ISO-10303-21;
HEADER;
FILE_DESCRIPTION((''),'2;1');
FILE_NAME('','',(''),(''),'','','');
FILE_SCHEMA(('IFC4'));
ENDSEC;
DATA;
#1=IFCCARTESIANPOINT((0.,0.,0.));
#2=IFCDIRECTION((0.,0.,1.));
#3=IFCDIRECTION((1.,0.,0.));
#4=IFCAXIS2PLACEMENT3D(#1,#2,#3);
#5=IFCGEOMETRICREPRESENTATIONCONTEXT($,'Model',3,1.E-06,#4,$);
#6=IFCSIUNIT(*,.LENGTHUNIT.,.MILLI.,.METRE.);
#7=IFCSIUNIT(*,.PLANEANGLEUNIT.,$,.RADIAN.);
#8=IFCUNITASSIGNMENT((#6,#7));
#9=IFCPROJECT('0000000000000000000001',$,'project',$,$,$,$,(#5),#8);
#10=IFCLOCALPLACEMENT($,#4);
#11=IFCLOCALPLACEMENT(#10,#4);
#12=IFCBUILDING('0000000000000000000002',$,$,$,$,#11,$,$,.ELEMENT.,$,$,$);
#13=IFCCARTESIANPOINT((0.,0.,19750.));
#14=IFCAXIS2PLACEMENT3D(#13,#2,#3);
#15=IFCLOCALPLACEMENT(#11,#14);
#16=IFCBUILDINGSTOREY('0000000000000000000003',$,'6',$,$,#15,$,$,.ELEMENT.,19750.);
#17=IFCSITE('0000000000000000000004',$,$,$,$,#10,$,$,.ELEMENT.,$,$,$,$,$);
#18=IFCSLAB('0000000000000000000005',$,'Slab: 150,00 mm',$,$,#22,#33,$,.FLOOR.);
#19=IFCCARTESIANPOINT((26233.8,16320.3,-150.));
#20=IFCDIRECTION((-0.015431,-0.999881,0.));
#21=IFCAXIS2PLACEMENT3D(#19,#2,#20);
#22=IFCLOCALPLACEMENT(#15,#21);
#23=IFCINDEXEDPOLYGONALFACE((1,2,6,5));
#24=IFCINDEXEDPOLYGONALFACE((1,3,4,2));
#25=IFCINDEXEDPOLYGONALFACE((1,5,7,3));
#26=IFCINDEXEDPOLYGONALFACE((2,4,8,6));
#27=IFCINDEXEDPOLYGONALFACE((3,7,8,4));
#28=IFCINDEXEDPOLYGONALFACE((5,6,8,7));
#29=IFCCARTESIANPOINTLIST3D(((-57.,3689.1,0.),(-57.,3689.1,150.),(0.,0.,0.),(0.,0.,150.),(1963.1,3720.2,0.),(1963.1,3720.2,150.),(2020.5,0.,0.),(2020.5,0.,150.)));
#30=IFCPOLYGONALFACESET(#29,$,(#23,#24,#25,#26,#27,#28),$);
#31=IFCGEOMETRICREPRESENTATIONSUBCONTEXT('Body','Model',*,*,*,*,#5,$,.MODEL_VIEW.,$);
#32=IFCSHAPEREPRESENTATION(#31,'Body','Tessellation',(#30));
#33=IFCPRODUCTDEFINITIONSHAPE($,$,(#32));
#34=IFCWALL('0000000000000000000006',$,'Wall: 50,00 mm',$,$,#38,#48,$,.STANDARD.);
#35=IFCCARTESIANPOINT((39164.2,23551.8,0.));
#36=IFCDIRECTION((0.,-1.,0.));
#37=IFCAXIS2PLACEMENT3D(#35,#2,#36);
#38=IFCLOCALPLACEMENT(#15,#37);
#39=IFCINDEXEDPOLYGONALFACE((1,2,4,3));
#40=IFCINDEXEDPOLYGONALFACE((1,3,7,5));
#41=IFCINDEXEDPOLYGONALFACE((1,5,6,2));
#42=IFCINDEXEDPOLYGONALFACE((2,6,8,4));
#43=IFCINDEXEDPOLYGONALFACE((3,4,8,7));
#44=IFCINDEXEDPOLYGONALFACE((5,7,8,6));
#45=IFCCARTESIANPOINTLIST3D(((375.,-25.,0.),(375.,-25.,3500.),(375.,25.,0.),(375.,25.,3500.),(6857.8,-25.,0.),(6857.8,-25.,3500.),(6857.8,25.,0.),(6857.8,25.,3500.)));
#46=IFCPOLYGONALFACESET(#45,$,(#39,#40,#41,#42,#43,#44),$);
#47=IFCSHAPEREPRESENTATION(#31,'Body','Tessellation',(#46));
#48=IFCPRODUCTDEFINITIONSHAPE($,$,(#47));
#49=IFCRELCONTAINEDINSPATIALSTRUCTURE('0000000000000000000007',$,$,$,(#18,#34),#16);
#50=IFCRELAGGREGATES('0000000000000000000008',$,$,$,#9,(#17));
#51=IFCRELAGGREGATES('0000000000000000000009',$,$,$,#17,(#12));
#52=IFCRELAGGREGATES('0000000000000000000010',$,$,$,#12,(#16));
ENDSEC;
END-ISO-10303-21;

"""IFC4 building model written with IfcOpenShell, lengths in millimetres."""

from ifc_helpers import new_model, si_unit, frame, origin_with_axes, place, context, subcontext, project, spatial, line, indexed_curve, outline, extrude, element, save


model = new_model("IFC4")

# Units and contexts
model_context = context("Model", 3, precision=1e-06, world=origin_with_axes())
body_context = subcontext(model_context, "Body", "Model", "MODEL_VIEW")
ifc_project = project(units=[si_unit("LENGTHUNIT", "METRE", prefix="MILLI"), si_unit("PLANEANGLEUNIT", "RADIAN")], contexts=[model_context])

# Site, building, storey
site_placement = place(None, origin_with_axes())
site = spatial("IfcSite", under=ifc_project, at=site_placement, CompositionType="ELEMENT")
building_placement = place(site_placement, origin_with_axes())
building = spatial("IfcBuilding", under=site, at=building_placement, CompositionType="ELEMENT")
storey_placement = place(building_placement, frame((0.0, 0.0, 19750.0), z_axis=(0.0, 0.0, 1.0), x_axis=(1.0, 0.0, 0.0)))
storey = spatial("IfcBuildingStorey", under=building, at=storey_placement, Name="6", CompositionType="ELEMENT", Elevation=19750.0)

# Slab
slab_placement = place(storey_placement, frame((26233.8, 16320.3, -150.0), z_axis=(0.0, 0.0, 1.0), x_axis=(-0.015431, -0.999881, 0.0)))
element("IfcSlab", 1, at=slab_placement, inside=storey, Name="Slab: 150,00 mm", PredefinedType="FLOOR", context=body_context, shape_type="SweptSolid", body=[
    extrude(outline(indexed_curve([(0.0, 0.0), (2020.5, 0.0), (1963.1, 3720.2), (-57.0, 3689.1)], segments=[line(1, 2), line(2, 3), line(3, 4), line(4, 1)])), origin_with_axes(), (0.0, 0.0, 1.0), 150.0),
])

# Wall
wall_1_placement = place(storey_placement, frame((39164.2, 23551.8, 0.0), z_axis=(0.0, 0.0, 1.0), x_axis=(0.0, -1.0, 0.0)))
element("IfcWall", 2, at=wall_1_placement, inside=storey, Name="Wall: 50,00 mm", PredefinedType="STANDARD", context=body_context, shape_type="SweptSolid", body=[
    extrude(outline(indexed_curve([(375.0, -25.0), (6857.8, -25.0), (6857.8, 25.0), (375.0, 25.0)], segments=[line(1, 2), line(2, 3), line(3, 4), line(4, 1)])), origin_with_axes(), (0.0, 0.0, 1.0), 3500.0),
])

save(model, "model.ifc")
